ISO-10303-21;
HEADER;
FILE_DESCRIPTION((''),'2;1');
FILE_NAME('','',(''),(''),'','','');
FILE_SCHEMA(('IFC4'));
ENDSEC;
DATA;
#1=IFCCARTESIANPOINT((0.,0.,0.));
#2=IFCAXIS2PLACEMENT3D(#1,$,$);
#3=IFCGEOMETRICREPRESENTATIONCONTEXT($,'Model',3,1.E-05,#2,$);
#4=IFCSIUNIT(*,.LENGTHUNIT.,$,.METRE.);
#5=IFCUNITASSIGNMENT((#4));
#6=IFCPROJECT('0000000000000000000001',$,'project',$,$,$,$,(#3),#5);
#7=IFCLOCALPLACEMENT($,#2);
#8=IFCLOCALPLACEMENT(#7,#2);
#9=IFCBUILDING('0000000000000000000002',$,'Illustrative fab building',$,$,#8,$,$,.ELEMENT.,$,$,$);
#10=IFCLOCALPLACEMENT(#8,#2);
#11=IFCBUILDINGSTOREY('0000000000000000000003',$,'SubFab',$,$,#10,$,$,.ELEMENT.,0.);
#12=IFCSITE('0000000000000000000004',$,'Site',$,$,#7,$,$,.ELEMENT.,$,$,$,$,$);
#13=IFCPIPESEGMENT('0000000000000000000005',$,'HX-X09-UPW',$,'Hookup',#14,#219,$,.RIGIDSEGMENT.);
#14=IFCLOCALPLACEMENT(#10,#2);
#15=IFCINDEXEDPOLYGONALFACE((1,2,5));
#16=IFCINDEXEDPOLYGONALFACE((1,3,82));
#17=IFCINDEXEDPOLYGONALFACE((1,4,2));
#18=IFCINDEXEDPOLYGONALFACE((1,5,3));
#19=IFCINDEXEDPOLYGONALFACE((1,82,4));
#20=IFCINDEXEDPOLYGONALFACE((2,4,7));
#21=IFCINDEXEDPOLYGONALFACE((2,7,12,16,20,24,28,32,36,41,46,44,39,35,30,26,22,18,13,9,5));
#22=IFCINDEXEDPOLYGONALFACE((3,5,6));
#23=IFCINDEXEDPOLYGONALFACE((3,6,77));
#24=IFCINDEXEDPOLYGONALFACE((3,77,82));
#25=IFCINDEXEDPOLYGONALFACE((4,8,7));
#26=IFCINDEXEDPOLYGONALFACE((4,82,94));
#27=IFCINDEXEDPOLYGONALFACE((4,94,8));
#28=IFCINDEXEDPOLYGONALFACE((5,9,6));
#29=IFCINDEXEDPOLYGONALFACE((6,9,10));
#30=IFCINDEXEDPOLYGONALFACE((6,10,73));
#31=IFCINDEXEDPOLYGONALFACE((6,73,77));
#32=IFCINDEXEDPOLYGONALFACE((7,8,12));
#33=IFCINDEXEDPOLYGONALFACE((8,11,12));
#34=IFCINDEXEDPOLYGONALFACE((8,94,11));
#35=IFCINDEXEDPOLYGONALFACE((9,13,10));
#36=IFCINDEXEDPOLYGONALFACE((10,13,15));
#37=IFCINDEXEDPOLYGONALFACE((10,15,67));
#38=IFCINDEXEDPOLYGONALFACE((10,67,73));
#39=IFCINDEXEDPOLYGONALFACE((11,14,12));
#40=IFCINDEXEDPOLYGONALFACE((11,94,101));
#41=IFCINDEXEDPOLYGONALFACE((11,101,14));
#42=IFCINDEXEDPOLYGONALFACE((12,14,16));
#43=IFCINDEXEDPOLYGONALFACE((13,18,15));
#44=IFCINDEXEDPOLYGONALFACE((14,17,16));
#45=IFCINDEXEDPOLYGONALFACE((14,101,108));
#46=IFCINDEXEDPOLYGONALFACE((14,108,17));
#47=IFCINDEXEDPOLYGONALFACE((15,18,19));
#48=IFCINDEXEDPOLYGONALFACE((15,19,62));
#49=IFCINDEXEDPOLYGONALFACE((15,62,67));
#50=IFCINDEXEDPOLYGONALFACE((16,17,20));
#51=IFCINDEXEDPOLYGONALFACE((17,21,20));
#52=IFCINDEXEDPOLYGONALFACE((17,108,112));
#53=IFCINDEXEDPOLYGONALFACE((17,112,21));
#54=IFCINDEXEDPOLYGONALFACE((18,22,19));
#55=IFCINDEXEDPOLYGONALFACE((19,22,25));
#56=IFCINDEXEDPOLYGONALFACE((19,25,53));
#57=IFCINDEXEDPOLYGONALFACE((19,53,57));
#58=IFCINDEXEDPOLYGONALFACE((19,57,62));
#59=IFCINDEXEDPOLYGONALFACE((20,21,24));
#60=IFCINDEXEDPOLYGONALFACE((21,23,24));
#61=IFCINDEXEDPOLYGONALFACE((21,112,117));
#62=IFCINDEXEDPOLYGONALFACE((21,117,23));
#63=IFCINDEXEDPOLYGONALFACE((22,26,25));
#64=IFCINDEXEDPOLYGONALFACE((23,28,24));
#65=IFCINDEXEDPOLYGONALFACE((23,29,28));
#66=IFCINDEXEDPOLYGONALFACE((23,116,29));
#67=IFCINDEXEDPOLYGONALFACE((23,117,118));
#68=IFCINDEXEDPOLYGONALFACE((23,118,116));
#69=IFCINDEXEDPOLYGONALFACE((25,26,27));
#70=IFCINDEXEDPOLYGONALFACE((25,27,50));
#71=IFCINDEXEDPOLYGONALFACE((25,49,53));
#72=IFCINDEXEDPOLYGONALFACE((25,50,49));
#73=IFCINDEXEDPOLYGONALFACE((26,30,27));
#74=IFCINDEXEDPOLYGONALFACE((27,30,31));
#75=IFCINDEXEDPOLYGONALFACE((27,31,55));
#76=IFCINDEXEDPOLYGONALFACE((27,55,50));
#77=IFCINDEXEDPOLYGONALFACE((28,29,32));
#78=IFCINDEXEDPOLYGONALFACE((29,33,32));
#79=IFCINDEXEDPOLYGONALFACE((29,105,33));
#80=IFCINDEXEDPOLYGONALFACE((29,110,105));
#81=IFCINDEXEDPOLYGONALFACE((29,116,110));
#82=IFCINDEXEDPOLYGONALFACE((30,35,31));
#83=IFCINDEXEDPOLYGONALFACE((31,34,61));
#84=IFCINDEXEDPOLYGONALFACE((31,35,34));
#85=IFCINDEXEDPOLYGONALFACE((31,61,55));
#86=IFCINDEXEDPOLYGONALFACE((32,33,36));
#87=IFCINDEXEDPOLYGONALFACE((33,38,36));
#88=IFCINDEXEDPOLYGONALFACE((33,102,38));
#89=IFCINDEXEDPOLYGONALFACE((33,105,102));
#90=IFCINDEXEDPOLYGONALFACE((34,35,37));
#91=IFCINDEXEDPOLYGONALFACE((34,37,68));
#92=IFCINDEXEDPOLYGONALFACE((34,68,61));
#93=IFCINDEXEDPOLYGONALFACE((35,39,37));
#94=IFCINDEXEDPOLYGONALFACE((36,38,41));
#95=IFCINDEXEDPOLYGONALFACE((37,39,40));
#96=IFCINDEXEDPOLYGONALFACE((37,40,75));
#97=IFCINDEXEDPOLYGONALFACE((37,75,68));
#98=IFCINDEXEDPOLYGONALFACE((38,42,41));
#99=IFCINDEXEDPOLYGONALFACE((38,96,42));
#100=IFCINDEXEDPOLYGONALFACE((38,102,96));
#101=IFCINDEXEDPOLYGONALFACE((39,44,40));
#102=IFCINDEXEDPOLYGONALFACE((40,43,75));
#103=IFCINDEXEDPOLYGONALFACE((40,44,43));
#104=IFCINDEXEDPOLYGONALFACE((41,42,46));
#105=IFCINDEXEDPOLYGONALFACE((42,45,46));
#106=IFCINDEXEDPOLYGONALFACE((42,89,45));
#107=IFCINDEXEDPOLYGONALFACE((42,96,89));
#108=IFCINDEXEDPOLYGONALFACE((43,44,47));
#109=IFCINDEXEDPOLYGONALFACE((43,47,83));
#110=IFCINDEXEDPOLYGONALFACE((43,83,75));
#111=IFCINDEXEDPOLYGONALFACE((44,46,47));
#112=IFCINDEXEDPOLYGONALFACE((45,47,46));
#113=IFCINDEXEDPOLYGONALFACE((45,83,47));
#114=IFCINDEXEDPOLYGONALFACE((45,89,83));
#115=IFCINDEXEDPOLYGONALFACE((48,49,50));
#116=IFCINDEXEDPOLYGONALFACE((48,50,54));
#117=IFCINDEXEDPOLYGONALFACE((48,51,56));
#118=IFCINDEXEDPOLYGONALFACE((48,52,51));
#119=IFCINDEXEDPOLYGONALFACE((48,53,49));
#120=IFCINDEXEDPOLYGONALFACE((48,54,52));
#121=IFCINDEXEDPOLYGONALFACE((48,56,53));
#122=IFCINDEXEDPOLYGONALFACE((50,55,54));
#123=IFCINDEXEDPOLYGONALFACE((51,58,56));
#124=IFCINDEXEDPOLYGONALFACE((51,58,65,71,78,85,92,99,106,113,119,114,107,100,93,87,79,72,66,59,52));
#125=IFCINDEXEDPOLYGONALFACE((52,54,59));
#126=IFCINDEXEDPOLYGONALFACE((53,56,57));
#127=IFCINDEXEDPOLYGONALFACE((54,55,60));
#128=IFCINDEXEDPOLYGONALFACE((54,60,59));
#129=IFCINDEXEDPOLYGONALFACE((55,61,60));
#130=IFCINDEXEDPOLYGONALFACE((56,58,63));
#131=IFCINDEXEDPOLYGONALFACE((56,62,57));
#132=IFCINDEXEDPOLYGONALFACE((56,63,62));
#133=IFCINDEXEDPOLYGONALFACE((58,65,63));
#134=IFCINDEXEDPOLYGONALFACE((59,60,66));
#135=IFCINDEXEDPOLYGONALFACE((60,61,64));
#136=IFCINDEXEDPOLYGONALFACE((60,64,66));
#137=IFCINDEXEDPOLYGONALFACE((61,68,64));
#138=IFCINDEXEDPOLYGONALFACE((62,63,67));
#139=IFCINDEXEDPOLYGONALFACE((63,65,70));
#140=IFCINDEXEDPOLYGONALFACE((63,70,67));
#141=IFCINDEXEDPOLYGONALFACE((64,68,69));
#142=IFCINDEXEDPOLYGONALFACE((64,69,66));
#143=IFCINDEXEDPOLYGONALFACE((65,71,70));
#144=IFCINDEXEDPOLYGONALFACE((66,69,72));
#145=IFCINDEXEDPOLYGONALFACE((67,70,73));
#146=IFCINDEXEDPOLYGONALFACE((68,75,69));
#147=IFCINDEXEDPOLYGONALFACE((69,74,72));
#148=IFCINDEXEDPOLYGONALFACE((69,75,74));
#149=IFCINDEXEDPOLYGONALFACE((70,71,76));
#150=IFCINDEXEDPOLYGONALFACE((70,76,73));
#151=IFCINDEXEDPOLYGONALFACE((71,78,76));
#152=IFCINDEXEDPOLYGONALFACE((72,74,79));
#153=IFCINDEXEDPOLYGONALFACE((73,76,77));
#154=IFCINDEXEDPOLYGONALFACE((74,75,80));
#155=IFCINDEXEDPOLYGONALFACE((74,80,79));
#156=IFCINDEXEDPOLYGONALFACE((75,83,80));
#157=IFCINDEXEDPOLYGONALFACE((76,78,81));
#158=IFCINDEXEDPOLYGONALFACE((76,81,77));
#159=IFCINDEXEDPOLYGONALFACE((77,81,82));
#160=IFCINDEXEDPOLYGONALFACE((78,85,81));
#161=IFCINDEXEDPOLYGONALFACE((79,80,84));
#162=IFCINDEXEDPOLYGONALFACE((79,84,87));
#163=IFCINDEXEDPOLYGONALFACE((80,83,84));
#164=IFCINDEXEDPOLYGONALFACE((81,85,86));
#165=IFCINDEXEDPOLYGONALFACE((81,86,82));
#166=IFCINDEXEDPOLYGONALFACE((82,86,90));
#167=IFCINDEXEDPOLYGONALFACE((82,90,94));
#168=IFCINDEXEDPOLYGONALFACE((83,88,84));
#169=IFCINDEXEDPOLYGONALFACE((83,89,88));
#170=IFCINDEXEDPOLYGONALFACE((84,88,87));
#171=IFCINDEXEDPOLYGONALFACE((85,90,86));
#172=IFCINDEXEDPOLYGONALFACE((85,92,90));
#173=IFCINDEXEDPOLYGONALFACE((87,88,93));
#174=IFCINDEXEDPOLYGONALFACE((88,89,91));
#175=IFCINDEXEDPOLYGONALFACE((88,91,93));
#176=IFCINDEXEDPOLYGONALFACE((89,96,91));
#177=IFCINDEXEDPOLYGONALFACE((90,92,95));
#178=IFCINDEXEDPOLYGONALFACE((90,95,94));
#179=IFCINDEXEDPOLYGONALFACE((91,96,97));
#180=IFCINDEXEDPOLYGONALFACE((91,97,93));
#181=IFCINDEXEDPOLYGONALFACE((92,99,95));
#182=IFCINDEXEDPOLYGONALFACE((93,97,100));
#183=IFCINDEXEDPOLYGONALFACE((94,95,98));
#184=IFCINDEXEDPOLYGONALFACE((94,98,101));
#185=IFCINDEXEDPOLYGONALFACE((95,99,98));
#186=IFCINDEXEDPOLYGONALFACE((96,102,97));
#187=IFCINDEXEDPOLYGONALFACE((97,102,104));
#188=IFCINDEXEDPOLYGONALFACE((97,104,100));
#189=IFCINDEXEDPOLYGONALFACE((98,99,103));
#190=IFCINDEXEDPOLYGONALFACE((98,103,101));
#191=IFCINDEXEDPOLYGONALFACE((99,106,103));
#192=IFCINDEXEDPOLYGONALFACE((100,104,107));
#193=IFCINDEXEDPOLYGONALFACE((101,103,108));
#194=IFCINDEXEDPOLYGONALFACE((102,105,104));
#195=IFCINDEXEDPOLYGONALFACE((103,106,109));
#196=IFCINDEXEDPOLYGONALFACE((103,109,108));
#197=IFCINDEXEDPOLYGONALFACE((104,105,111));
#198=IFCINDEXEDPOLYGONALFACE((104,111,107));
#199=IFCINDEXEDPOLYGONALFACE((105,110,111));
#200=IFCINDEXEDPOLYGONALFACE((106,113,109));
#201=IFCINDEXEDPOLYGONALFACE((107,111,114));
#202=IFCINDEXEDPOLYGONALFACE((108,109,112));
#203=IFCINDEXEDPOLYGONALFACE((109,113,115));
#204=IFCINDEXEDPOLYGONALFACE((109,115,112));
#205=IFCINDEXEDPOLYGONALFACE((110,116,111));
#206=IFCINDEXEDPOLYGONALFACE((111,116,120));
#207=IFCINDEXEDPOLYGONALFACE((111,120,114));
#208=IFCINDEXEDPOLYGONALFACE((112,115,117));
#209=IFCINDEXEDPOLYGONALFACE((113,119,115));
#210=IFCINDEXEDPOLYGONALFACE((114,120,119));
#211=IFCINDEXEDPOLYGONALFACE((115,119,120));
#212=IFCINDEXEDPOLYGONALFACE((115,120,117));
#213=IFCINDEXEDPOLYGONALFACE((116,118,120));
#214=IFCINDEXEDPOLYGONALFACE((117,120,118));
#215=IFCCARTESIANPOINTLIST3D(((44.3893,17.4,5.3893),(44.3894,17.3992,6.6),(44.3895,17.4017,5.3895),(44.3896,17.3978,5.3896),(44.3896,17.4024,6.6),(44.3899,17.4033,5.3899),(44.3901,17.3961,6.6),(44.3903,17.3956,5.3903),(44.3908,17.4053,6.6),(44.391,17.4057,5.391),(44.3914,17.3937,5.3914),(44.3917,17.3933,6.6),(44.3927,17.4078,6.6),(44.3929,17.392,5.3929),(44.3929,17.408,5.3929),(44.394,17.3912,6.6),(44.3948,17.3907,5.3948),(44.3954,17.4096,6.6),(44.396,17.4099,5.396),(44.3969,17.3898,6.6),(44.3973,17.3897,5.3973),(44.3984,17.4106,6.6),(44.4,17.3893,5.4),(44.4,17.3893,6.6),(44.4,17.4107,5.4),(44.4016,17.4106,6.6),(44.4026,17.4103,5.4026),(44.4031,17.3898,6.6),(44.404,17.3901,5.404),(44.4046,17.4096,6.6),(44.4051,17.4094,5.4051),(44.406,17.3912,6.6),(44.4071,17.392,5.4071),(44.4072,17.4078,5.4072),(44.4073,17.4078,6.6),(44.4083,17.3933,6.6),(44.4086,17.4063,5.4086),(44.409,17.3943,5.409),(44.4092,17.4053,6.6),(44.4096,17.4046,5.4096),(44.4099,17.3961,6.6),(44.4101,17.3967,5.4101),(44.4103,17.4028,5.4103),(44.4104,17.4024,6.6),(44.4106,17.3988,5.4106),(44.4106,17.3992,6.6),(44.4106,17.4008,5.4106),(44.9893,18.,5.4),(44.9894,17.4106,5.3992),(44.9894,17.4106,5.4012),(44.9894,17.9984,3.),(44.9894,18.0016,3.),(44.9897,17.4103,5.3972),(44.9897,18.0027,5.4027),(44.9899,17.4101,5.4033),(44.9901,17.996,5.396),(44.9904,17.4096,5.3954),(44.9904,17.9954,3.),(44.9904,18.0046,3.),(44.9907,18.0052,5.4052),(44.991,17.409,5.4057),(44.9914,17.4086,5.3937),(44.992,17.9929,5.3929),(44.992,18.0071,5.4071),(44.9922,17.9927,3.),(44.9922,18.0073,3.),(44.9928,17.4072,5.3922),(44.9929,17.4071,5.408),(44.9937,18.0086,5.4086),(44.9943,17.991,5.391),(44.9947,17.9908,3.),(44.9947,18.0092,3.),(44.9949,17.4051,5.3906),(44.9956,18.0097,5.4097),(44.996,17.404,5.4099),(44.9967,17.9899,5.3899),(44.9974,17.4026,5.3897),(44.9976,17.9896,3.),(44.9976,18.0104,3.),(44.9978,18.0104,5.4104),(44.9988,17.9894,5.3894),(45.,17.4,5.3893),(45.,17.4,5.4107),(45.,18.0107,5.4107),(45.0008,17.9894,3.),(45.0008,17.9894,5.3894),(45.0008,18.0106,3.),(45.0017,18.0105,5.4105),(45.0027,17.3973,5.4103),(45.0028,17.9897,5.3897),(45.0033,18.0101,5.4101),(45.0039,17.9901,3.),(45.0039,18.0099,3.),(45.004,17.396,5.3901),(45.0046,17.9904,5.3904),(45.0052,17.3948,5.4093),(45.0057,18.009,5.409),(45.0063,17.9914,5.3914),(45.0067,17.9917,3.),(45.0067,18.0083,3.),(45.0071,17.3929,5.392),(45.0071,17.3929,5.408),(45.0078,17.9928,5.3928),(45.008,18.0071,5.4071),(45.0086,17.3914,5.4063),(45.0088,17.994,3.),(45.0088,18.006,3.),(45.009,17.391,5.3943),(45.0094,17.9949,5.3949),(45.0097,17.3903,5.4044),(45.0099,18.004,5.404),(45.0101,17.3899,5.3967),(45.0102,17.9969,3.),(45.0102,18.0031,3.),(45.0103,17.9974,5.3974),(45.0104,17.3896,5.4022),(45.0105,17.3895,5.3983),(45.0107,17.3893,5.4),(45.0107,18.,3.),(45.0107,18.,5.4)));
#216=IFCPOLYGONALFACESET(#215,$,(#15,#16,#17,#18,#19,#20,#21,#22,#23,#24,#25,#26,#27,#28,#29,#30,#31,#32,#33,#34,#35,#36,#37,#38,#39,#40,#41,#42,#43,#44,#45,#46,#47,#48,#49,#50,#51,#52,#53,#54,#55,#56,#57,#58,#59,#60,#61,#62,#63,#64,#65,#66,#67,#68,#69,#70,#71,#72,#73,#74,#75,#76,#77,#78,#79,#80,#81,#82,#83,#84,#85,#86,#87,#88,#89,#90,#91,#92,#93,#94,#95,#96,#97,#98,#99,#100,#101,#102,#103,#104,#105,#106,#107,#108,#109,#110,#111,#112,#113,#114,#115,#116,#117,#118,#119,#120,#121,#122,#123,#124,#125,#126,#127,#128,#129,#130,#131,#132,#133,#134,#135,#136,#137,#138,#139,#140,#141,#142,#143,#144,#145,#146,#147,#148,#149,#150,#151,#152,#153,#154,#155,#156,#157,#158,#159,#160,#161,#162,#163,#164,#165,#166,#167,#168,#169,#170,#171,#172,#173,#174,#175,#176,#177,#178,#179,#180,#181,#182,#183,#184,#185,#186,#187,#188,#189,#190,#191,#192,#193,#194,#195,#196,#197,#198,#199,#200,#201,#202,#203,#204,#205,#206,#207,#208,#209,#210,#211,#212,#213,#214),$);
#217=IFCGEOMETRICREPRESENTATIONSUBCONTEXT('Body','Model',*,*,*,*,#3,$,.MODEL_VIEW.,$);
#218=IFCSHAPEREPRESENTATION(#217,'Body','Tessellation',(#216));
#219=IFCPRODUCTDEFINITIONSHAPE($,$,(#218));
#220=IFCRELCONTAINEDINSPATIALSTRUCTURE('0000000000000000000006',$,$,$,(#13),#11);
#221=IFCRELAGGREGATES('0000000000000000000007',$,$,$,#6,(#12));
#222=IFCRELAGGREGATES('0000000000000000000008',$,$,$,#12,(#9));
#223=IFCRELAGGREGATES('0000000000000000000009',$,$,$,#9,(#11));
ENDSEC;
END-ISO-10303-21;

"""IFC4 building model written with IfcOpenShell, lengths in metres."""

from ifc_helpers import new_model, entity, si_unit, origin, place, context, subcontext, project, spatial, element, save


model = new_model("IFC4")

# Units and contexts
model_context = context("Model", 3, precision=1e-05, world=origin())
body_context = subcontext(model_context, "Body", "Model", "MODEL_VIEW")
ifc_project = project(units=[si_unit("LENGTHUNIT", "METRE")], contexts=[model_context])

# Site, building, storey
site_placement = place(None, origin())
site = spatial("IfcSite", under=ifc_project, at=site_placement, Name="Site", CompositionType="ELEMENT")
building_placement = place(site_placement, origin())
building = spatial("IfcBuilding", under=site, at=building_placement, Name="Illustrative fab building", CompositionType="ELEMENT")
storey_placement = place(building_placement, origin())
storey = spatial("IfcBuildingStorey", under=building, at=storey_placement, Name="SubFab", CompositionType="ELEMENT", Elevation=0.0)

# Pipe segment
pipe_segment_1_placement = place(storey_placement, origin())
element("IfcPipeSegment", 1, at=pipe_segment_1_placement, inside=storey, Name="HX-X09-UPW", ObjectType="Hookup", PredefinedType="RIGIDSEGMENT", context=body_context, shape_type="AdvancedSweptSolid", body=[
    entity("IfcSweptDiskSolid", entity("IfcPolyline", [entity("IfcCartesianPoint", [45.0, 18.0, 3.0]), entity("IfcCartesianPoint", [45.0, 18.0, 5.4]), entity("IfcCartesianPoint", [45.0, 17.4, 5.4]), entity("IfcCartesianPoint", [44.4, 17.4, 5.4]), entity("IfcCartesianPoint", [44.4, 17.4, 6.6])]), 0.0107),
])

save(model, "model.ifc")
